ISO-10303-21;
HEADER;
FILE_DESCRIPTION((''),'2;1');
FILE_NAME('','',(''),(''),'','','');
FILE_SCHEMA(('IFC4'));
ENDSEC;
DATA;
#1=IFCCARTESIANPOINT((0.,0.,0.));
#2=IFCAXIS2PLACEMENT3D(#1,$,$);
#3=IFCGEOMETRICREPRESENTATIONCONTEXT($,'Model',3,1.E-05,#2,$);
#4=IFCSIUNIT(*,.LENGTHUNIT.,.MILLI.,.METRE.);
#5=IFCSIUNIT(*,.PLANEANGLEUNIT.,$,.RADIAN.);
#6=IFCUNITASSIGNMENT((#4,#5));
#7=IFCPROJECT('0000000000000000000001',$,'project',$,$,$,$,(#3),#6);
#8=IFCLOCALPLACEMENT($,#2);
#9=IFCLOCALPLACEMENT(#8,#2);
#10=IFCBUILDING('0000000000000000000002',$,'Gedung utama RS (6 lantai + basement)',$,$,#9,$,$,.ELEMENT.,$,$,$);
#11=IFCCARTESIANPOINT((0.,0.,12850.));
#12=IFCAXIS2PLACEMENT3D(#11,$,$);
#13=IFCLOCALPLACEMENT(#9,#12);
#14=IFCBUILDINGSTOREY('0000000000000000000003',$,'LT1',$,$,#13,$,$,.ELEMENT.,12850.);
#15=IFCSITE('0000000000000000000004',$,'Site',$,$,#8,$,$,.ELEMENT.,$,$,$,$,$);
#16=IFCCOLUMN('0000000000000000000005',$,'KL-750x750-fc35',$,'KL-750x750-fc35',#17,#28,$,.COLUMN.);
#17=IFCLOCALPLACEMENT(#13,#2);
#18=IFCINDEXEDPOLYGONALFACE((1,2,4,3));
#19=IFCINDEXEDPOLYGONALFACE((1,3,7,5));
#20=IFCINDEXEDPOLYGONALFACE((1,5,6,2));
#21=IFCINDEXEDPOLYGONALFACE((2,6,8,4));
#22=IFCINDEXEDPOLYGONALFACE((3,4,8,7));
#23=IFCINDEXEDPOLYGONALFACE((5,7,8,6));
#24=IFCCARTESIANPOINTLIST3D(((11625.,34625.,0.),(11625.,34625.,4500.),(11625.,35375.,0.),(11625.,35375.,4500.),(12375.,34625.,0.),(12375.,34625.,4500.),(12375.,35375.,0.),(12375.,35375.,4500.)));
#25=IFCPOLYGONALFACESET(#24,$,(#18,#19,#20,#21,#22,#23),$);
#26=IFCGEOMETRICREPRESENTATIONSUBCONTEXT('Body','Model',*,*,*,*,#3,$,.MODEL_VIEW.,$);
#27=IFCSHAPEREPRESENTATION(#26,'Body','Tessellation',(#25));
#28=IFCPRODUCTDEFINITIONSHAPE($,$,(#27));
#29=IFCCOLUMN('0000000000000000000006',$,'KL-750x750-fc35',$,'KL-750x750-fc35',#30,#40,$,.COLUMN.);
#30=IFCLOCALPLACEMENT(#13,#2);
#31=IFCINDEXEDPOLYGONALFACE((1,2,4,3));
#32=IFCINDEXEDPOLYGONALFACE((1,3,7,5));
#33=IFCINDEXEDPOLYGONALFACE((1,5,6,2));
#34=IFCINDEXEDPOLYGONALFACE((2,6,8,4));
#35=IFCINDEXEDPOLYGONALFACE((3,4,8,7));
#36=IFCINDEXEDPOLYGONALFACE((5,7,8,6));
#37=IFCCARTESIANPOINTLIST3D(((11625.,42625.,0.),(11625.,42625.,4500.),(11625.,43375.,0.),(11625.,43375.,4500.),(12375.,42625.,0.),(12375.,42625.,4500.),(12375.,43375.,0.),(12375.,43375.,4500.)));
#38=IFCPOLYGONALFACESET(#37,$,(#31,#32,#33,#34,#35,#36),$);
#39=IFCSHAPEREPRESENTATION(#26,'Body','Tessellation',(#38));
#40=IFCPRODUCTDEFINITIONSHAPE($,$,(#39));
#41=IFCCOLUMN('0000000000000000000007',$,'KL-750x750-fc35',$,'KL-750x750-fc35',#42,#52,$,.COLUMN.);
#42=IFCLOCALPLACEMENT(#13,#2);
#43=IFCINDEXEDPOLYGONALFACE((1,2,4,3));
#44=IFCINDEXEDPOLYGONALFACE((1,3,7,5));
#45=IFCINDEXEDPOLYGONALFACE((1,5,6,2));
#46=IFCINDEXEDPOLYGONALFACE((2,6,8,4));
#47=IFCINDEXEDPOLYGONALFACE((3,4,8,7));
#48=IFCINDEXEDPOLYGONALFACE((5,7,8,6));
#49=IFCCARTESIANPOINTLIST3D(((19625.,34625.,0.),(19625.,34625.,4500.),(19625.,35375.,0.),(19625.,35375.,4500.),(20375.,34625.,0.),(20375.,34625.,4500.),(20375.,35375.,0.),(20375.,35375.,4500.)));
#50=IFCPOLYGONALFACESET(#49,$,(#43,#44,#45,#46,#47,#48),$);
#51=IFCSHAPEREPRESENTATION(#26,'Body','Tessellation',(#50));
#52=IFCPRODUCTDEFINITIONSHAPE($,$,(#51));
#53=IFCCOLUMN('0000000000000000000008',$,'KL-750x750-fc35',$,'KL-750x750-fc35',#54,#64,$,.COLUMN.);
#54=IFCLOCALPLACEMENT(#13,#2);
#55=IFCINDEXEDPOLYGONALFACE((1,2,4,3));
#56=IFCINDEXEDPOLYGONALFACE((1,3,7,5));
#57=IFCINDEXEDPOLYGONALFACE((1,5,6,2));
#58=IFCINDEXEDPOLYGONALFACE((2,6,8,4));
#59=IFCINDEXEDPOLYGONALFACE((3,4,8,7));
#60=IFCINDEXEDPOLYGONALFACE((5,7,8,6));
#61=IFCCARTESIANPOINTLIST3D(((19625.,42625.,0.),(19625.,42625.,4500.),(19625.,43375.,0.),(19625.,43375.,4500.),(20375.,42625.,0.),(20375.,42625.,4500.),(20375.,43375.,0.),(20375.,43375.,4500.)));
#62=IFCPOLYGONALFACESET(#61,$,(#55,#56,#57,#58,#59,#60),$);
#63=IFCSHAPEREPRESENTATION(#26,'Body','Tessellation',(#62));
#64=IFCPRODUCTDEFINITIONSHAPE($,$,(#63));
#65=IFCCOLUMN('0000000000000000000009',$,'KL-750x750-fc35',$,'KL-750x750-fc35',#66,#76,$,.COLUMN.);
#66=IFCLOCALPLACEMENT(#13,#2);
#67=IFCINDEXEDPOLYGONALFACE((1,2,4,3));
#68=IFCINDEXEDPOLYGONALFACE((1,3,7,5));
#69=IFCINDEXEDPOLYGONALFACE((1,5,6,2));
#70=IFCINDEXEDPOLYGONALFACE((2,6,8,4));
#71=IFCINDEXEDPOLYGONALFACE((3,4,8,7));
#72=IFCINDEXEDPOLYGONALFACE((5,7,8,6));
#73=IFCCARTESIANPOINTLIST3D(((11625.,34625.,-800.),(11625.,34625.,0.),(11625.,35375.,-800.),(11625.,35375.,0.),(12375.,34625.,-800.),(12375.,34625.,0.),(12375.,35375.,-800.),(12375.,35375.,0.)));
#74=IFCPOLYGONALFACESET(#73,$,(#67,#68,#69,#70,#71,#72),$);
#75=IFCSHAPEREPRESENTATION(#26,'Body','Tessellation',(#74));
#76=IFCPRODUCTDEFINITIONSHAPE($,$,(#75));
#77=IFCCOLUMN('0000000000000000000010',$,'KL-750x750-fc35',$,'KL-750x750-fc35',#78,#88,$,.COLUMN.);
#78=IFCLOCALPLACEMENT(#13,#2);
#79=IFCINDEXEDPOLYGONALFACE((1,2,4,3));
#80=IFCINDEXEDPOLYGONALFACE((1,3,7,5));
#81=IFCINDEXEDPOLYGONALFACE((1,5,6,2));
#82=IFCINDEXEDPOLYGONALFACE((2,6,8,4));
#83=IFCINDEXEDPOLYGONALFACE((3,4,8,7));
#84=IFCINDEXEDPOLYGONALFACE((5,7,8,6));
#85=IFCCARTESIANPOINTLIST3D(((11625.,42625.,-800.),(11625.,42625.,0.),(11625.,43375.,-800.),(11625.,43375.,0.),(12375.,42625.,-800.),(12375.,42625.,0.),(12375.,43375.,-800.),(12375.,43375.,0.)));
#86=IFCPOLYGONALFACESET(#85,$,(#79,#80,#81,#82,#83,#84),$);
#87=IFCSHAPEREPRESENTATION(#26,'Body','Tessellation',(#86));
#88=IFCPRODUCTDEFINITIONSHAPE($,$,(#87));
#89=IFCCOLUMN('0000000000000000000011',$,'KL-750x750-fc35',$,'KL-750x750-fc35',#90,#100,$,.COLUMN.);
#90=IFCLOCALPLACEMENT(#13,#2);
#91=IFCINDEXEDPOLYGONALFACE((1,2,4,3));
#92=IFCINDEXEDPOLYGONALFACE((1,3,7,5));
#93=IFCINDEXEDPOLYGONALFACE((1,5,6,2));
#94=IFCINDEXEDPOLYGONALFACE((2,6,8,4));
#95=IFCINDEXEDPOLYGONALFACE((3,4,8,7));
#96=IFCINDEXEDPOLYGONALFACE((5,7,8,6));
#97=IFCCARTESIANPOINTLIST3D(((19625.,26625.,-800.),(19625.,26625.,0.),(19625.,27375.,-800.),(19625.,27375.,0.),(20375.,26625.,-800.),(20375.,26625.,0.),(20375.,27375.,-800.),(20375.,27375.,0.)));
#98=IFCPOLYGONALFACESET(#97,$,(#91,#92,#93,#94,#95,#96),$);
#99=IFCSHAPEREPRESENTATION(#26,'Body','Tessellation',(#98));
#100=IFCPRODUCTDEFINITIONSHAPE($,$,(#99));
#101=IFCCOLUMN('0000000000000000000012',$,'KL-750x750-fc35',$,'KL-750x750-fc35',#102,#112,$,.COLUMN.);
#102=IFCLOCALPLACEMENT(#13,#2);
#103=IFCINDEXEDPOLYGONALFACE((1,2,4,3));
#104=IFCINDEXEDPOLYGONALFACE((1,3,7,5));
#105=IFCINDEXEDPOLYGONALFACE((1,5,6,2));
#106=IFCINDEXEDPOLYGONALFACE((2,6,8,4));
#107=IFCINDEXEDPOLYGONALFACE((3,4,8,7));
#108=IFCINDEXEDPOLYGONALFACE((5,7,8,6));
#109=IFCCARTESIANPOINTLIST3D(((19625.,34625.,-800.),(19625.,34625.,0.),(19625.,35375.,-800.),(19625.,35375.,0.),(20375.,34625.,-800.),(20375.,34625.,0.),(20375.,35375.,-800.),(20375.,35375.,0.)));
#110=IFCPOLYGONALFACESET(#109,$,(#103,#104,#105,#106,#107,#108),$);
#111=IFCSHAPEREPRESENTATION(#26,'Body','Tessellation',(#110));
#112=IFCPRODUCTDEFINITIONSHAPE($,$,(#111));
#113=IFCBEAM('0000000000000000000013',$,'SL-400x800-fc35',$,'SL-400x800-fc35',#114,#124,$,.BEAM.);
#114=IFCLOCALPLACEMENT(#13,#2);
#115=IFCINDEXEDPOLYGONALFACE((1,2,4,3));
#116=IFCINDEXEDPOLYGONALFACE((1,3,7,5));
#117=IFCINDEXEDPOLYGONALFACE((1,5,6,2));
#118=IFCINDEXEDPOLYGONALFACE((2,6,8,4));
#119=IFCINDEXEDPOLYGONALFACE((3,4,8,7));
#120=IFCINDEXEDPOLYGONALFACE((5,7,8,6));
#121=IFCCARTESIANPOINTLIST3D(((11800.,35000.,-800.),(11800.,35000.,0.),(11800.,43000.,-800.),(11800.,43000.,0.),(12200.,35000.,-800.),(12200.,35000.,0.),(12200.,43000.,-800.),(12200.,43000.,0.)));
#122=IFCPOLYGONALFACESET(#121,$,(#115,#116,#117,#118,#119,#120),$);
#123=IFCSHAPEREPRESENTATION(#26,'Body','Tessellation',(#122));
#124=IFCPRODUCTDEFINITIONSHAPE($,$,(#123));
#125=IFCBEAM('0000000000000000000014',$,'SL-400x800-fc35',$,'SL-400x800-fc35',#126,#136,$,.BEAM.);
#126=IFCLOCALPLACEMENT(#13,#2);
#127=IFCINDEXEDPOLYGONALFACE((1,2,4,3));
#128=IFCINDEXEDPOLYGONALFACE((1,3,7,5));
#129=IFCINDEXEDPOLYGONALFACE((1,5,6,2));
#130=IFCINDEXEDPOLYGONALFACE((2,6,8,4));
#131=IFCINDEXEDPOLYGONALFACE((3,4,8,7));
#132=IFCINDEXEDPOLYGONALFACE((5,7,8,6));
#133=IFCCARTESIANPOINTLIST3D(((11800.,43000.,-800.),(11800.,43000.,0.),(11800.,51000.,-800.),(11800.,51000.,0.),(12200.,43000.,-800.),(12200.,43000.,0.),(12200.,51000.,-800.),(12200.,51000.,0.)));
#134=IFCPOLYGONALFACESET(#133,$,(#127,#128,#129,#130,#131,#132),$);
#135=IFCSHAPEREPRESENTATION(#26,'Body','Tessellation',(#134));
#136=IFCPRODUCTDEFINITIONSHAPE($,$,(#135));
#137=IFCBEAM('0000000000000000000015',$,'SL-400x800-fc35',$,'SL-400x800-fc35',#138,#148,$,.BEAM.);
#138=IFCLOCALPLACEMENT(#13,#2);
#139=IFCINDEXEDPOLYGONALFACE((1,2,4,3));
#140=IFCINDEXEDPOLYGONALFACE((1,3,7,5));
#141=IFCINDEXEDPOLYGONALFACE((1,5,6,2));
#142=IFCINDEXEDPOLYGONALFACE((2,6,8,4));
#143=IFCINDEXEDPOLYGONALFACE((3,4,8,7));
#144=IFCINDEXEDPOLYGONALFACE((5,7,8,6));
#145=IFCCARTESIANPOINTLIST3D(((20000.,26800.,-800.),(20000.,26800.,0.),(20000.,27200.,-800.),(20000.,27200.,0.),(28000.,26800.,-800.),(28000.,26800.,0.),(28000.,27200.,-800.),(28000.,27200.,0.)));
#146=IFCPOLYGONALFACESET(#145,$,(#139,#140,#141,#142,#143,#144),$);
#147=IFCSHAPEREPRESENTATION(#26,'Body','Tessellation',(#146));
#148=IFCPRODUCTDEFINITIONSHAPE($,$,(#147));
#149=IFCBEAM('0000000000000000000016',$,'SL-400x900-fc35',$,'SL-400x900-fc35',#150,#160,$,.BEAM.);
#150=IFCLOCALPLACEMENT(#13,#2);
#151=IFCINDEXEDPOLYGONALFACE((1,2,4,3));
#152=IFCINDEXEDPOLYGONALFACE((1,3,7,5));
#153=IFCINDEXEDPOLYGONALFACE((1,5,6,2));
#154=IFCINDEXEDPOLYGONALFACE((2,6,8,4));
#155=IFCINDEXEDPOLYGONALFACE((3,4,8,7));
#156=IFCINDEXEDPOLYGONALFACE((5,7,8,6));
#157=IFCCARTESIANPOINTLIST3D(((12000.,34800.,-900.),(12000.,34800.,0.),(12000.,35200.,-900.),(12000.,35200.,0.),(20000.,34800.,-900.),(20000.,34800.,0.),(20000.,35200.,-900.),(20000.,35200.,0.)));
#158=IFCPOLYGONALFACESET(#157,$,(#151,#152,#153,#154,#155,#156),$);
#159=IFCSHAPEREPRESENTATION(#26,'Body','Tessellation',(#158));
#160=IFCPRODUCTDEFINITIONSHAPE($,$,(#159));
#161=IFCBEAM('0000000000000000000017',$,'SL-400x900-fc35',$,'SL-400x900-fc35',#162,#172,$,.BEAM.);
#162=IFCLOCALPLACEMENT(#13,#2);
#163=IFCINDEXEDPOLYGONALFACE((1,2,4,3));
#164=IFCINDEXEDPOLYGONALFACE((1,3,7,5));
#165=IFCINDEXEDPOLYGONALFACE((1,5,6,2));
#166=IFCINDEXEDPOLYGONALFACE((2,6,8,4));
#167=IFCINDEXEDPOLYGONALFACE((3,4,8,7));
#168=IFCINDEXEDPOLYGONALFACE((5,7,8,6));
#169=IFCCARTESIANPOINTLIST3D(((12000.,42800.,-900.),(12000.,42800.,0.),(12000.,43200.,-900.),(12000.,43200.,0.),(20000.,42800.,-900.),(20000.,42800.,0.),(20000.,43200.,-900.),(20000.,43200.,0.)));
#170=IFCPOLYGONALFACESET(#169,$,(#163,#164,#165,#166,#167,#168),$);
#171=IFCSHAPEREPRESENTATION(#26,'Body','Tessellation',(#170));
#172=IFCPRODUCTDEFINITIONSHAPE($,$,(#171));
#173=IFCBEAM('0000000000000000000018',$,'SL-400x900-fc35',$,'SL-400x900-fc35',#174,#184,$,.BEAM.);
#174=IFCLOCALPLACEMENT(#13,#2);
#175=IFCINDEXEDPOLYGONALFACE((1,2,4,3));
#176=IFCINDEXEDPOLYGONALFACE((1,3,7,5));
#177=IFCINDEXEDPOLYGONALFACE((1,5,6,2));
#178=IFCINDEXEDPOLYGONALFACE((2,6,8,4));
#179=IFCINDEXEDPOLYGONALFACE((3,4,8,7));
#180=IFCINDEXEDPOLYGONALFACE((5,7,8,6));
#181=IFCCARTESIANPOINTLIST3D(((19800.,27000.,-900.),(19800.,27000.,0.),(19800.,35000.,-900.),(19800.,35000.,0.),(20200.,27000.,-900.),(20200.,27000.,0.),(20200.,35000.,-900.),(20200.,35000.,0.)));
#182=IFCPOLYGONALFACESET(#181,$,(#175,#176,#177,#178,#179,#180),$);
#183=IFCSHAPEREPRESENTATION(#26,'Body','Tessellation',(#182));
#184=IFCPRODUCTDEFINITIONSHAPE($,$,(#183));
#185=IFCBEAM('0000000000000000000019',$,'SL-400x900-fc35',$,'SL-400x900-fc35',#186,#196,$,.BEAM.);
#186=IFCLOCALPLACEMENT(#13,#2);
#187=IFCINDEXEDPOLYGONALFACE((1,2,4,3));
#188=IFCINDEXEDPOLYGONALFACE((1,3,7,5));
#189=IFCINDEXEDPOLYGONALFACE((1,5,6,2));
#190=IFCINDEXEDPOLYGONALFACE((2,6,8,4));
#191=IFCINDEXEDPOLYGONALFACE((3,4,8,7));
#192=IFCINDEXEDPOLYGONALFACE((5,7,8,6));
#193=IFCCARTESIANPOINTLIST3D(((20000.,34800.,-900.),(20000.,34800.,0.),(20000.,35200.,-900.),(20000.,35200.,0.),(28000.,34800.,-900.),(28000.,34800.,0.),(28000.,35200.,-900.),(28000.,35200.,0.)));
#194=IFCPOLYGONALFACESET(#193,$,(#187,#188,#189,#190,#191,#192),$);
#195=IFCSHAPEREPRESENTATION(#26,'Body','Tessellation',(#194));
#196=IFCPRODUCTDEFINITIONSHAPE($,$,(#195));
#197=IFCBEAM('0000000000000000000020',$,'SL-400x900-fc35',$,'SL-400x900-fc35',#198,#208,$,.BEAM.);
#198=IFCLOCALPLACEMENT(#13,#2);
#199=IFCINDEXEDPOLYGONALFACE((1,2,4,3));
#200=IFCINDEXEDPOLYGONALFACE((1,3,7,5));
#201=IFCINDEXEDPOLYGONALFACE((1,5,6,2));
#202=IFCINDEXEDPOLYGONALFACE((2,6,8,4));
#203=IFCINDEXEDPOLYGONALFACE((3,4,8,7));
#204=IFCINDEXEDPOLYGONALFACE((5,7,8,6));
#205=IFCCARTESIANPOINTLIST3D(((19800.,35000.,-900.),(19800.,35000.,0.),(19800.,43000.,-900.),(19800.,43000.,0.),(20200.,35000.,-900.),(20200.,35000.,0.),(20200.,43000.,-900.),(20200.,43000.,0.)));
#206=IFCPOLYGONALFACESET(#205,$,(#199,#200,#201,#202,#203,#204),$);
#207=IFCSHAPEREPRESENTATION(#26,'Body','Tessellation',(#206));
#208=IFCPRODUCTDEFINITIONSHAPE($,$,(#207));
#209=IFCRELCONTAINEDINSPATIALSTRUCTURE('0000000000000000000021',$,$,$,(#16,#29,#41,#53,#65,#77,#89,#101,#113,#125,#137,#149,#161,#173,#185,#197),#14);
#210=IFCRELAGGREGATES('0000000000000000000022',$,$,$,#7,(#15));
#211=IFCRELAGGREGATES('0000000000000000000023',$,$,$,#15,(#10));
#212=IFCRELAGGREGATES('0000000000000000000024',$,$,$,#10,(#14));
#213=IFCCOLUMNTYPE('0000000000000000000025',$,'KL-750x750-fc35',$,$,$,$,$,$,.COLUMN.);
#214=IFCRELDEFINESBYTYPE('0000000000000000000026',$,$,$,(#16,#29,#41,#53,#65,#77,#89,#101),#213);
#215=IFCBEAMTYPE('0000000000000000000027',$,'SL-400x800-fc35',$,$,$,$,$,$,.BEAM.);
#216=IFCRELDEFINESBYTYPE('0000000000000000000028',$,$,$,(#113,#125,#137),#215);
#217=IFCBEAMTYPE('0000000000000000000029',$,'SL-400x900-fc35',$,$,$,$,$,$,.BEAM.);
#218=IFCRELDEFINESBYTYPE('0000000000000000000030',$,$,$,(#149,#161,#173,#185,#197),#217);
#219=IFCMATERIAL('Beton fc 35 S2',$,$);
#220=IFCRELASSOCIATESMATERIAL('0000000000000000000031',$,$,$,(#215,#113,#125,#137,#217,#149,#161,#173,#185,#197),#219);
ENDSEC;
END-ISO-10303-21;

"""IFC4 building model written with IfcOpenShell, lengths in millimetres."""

from ifc_helpers import new_model, si_unit, frame, origin, origin_2d, place, context, subcontext, project, spatial, rectangle, extrude, material, material_profile, profile_set, profile_usage, type_object, element, save


model = new_model("IFC4")

# Units and contexts
model_context = context("Model", 3, precision=1e-05, world=origin())
body_context = subcontext(model_context, "Body", "Model", "MODEL_VIEW")
ifc_project = project(units=[si_unit("LENGTHUNIT", "METRE", prefix="MILLI"), si_unit("PLANEANGLEUNIT", "RADIAN")], contexts=[model_context])

# Site, building, storey
site_placement = place(None, origin())
site = spatial("IfcSite", under=ifc_project, at=site_placement, Name="Site", CompositionType="ELEMENT")
building_placement = place(site_placement, origin())
building = spatial("IfcBuilding", under=site, at=building_placement, Name="Gedung utama RS (6 lantai + basement)", CompositionType="ELEMENT")
storey_placement = place(building_placement, frame((0.0, 0.0, 12850.0)))
storey = spatial("IfcBuildingStorey", under=building, at=storey_placement, Name="LT1", CompositionType="ELEMENT", Elevation=12850.0)

# Columns
ifc_material_profile_1 = material_profile(None, rectangle(XDim=750.0, YDim=750.0, at=origin_2d()), Name="KL-750x750-fc35")
ifc_profile_set_1 = profile_set([ifc_material_profile_1], Name="KL-750x750-fc35")
ifc_profile_usage_1 = profile_usage(ifc_profile_set_1, cardinal=5)
column_type = type_object("IfcColumnType", Name="KL-750x750-fc35", PredefinedType="COLUMN", material=ifc_profile_set_1)
for number, where, z_axis, x_axis, name in (
    (1, (12000.0, 35000.0, 0.0), (0.0, 0.0, 1.0), (1.0, 0.0, 0.0), "KL-750x750-fc35"),
    (2, (12000.0, 43000.0, 0.0), (0.0, 0.0, 1.0), (1.0, 0.0, 0.0), "KL-750x750-fc35"),
    (3, (20000.0, 35000.0, 0.0), (0.0, 0.0, 1.0), (1.0, 0.0, 0.0), "KL-750x750-fc35"),
    (4, (20000.0, 43000.0, 0.0), (0.0, 0.0, 1.0), (1.0, 0.0, 0.0), "KL-750x750-fc35"),
):
    element("IfcColumn", number, at=place(storey_placement, frame(where, z_axis=z_axis, x_axis=x_axis)), inside=storey, type_object=column_type, material=ifc_profile_usage_1, Name=name, ObjectType="KL-750x750-fc35", PredefinedType="COLUMN", context=body_context, shape_type="SweptSolid", body=[
        extrude(rectangle(XDim=750.0, YDim=750.0, at=origin_2d()), origin(), (0.0, 0.0, 1.0), 4500.0),
    ])
for number, where, z_axis, x_axis, name in (
    (5, (12000.0, 35000.0, -800.0), (0.0, 0.0, 1.0), (1.0, 0.0, 0.0), "KL-750x750-fc35"),
    (6, (12000.0, 43000.0, -800.0), (0.0, 0.0, 1.0), (1.0, 0.0, 0.0), "KL-750x750-fc35"),
    (7, (20000.0, 27000.0, -800.0), (0.0, 0.0, 1.0), (1.0, 0.0, 0.0), "KL-750x750-fc35"),
    (8, (20000.0, 35000.0, -800.0), (0.0, 0.0, 1.0), (1.0, 0.0, 0.0), "KL-750x750-fc35"),
):
    element("IfcColumn", number, at=place(storey_placement, frame(where, z_axis=z_axis, x_axis=x_axis)), inside=storey, type_object=column_type, material=ifc_profile_usage_1, Name=name, ObjectType="KL-750x750-fc35", PredefinedType="COLUMN", context=body_context, shape_type="SweptSolid", body=[
        extrude(rectangle(XDim=750.0, YDim=750.0, at=origin_2d()), origin(), (0.0, 0.0, 1.0), 800.0),
    ])

# Beams
ifc_material = material(Name="Beton fc 35 S2")
ifc_material_profile_2 = material_profile(ifc_material, rectangle(XDim=400.0, YDim=800.0, at=origin_2d()), Name="SL-400x800-fc35")
ifc_profile_set_2 = profile_set([ifc_material_profile_2], Name="SL-400x800-fc35")
ifc_profile_usage_2 = profile_usage(ifc_profile_set_2, cardinal=8)
beam_type_1 = type_object("IfcBeamType", Name="SL-400x800-fc35", PredefinedType="BEAM", material=ifc_profile_set_2)
for number, where, name in (
    (9, (12000.0, 35000.0, -400.0), "SL-400x800-fc35"),
    (10, (12000.0, 43000.0, -400.0), "SL-400x800-fc35"),
):
    element("IfcBeam", number, at=place(storey_placement, frame(where)), inside=storey, type_object=beam_type_1, material=ifc_profile_usage_2, Name=name, ObjectType="SL-400x800-fc35", PredefinedType="BEAM", context=body_context, shape_type="SweptSolid", body=[
        extrude(rectangle(XDim=400.0, YDim=800.0, at=origin_2d()), frame((0.0, 0.0, 0.0), z_axis=(0.0, 1.0, 0.0), x_axis=(-1.0, 0.0, 0.0)), (0.0, 0.0, 1.0), 8000.0),
    ])
beam_1_placement = place(storey_placement, frame((20000.0, 27000.0, -400.0)))
element("IfcBeam", 11, at=beam_1_placement, inside=storey, type_object=beam_type_1, material=ifc_profile_usage_2, Name="SL-400x800-fc35", ObjectType="SL-400x800-fc35", PredefinedType="BEAM", context=body_context, shape_type="SweptSolid", body=[
    extrude(rectangle(XDim=400.0, YDim=800.0, at=origin_2d()), frame((0.0, 0.0, 0.0), z_axis=(1.0, 0.0, 0.0), x_axis=(0.0, 1.0, 0.0)), (0.0, 0.0, 1.0), 8000.0),
])
ifc_material_profile_3 = material_profile(ifc_material, rectangle(XDim=400.0, YDim=900.0, at=origin_2d()), Name="SL-400x900-fc35")
ifc_profile_set_3 = profile_set([ifc_material_profile_3], Name="SL-400x900-fc35")
ifc_profile_usage_3 = profile_usage(ifc_profile_set_3, cardinal=8)
beam_type_2 = type_object("IfcBeamType", Name="SL-400x900-fc35", PredefinedType="BEAM", material=ifc_profile_set_3)
for number, where, name in (
    (12, (12000.0, 35000.0, -450.0), "SL-400x900-fc35"),
    (13, (12000.0, 43000.0, -450.0), "SL-400x900-fc35"),
):
    element("IfcBeam", number, at=place(storey_placement, frame(where)), inside=storey, type_object=beam_type_2, material=ifc_profile_usage_3, Name=name, ObjectType="SL-400x900-fc35", PredefinedType="BEAM", context=body_context, shape_type="SweptSolid", body=[
        extrude(rectangle(XDim=400.0, YDim=900.0, at=origin_2d()), frame((0.0, 0.0, 0.0), z_axis=(1.0, 0.0, 0.0), x_axis=(0.0, 1.0, 0.0)), (0.0, 0.0, 1.0), 8000.0),
    ])
beam_2_placement = place(storey_placement, frame((20000.0, 27000.0, -450.0)))
element("IfcBeam", 14, at=beam_2_placement, inside=storey, type_object=beam_type_2, material=ifc_profile_usage_3, Name="SL-400x900-fc35", ObjectType="SL-400x900-fc35", PredefinedType="BEAM", context=body_context, shape_type="SweptSolid", body=[
    extrude(rectangle(XDim=400.0, YDim=900.0, at=origin_2d()), frame((0.0, 0.0, 0.0), z_axis=(0.0, 1.0, 0.0), x_axis=(-1.0, 0.0, 0.0)), (0.0, 0.0, 1.0), 8000.0),
])
beam_3_placement = place(storey_placement, frame((20000.0, 35000.0, -450.0)))
element("IfcBeam", 15, at=beam_3_placement, inside=storey, type_object=beam_type_2, material=ifc_profile_usage_3, Name="SL-400x900-fc35", ObjectType="SL-400x900-fc35", PredefinedType="BEAM", context=body_context, shape_type="SweptSolid", body=[
    extrude(rectangle(XDim=400.0, YDim=900.0, at=origin_2d()), frame((0.0, 0.0, 0.0), z_axis=(1.0, 0.0, 0.0), x_axis=(0.0, 1.0, 0.0)), (0.0, 0.0, 1.0), 8000.0),
])
beam_4_placement = place(storey_placement, frame((20000.0, 35000.0, -450.0)))
element("IfcBeam", 16, at=beam_4_placement, inside=storey, type_object=beam_type_2, material=ifc_profile_usage_3, Name="SL-400x900-fc35", ObjectType="SL-400x900-fc35", PredefinedType="BEAM", context=body_context, shape_type="SweptSolid", body=[
    extrude(rectangle(XDim=400.0, YDim=900.0, at=origin_2d()), frame((0.0, 0.0, 0.0), z_axis=(0.0, 1.0, 0.0), x_axis=(-1.0, 0.0, 0.0)), (0.0, 0.0, 1.0), 8000.0),
])

save(model, "model.ifc")
